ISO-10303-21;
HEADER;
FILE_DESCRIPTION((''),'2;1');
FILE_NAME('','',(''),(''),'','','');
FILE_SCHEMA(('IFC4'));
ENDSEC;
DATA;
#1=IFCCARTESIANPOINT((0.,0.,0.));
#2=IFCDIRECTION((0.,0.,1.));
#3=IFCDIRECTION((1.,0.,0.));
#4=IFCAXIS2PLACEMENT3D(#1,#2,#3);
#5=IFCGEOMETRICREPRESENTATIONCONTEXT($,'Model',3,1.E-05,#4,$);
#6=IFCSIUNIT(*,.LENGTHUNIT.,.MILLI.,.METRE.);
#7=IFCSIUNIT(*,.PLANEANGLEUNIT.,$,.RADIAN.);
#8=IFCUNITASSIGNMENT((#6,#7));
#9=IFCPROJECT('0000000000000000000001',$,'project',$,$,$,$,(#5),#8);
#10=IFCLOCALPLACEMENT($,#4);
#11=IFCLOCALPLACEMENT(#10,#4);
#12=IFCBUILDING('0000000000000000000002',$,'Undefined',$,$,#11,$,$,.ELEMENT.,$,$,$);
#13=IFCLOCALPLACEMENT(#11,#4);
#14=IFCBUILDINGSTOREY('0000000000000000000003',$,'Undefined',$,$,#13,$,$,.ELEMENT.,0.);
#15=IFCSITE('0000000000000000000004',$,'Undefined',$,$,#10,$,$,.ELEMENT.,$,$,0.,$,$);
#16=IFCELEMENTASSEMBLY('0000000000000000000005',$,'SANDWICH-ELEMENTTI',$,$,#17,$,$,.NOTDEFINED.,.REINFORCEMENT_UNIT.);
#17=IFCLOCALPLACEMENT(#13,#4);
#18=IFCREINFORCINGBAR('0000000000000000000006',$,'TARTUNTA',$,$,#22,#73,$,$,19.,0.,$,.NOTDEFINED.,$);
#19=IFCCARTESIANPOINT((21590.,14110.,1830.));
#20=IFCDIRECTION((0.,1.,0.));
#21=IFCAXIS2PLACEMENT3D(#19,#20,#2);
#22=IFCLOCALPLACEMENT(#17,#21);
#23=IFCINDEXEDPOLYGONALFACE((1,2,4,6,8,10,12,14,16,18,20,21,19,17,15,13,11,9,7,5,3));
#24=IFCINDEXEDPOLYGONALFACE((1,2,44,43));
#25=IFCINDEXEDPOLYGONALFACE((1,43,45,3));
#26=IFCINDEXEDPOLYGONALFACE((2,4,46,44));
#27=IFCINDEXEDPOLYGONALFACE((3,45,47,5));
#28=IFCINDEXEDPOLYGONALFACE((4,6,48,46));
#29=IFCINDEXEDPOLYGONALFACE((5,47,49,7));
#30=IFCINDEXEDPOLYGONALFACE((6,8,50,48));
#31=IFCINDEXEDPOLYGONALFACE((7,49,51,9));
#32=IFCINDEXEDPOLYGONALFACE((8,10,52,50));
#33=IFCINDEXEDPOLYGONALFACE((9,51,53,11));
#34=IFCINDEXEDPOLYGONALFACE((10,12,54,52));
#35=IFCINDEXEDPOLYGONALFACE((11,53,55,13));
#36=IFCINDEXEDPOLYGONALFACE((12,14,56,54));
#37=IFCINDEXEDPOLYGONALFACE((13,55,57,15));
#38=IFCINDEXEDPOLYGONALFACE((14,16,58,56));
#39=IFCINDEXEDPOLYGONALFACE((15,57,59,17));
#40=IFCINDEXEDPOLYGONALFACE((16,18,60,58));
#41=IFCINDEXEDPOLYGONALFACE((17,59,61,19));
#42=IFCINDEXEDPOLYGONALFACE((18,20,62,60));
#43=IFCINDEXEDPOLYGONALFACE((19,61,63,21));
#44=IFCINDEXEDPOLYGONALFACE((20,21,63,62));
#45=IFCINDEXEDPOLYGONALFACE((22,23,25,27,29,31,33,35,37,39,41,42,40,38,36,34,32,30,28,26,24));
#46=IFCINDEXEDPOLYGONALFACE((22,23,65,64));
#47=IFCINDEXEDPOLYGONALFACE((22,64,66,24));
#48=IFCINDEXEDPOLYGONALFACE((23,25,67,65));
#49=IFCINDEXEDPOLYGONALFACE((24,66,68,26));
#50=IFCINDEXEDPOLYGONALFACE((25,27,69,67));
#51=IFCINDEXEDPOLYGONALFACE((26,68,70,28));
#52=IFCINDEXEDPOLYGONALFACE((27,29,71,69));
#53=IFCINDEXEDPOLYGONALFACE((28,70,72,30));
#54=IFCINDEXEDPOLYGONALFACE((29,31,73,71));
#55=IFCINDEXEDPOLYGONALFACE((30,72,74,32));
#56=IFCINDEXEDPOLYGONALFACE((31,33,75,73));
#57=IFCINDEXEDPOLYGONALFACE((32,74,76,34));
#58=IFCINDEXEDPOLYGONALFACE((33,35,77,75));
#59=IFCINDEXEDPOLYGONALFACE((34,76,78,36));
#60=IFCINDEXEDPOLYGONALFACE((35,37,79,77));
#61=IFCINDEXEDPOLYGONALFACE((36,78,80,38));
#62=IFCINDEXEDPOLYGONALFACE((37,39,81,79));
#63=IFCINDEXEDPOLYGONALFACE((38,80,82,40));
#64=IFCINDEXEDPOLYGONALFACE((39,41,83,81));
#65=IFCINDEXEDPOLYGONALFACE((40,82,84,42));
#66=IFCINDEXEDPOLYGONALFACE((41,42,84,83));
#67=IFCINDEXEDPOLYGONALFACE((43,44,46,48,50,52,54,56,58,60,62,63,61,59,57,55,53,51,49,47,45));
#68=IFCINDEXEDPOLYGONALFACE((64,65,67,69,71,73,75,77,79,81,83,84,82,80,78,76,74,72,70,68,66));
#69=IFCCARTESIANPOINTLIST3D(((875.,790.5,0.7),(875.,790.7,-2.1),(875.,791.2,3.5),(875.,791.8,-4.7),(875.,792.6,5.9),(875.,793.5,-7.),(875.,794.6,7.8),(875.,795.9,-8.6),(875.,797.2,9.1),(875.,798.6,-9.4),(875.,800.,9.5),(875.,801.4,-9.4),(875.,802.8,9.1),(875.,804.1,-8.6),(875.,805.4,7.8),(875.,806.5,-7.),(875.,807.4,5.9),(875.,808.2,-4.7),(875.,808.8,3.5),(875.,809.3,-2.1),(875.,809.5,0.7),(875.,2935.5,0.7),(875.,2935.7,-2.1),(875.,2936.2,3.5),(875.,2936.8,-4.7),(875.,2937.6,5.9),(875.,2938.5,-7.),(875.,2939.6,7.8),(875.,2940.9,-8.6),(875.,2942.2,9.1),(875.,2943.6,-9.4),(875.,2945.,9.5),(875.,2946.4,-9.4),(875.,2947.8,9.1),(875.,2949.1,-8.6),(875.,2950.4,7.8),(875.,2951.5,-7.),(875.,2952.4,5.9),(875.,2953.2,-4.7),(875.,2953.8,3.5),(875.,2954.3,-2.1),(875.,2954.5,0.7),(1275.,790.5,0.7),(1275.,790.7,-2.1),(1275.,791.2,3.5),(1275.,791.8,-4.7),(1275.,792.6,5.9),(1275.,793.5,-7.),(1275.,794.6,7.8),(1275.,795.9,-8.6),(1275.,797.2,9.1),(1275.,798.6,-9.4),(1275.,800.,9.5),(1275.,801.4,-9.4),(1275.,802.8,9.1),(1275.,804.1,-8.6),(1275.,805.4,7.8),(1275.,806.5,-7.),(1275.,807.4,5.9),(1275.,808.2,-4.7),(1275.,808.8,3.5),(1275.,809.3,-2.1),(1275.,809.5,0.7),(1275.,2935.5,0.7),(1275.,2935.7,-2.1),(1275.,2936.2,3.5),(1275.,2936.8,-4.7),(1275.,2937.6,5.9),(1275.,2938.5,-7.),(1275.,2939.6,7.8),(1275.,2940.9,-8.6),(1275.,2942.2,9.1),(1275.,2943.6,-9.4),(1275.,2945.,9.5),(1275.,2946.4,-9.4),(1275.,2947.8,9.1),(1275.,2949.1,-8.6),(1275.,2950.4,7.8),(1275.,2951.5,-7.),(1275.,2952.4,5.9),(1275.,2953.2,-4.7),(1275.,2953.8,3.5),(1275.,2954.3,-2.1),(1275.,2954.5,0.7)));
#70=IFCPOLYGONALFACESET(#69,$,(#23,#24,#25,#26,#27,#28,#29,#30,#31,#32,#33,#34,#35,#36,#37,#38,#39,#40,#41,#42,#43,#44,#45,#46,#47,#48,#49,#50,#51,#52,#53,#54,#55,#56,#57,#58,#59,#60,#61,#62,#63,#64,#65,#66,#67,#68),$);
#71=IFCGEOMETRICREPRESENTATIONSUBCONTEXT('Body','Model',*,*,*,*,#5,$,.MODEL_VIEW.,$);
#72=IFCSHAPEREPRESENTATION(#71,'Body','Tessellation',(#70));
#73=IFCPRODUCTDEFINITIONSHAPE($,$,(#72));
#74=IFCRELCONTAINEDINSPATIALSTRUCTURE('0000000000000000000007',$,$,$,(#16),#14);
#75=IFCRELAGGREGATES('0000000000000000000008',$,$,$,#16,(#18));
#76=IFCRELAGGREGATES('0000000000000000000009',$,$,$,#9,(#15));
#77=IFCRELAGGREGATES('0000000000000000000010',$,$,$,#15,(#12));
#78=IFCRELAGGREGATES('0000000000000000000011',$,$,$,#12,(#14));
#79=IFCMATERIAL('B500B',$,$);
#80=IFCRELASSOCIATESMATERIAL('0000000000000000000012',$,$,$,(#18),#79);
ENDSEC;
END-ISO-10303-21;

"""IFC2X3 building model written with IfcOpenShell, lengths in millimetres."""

from ifc_helpers import new_model, entity, si_unit, frame, origin_with_axes, place, context, subcontext, project, spatial, source, transform, mapped, material, element, aggregate, save


model = new_model("IFC2X3")

# Units and contexts
model_context = context("Model", 3, precision=1e-05, world=origin_with_axes())
body_context = subcontext(model_context, "Body", "Model", "MODEL_VIEW")
ifc_project = project(units=[si_unit("LENGTHUNIT", "METRE", prefix="MILLI"), si_unit("PLANEANGLEUNIT", "RADIAN")], contexts=[model_context])

# Site, building, storey
site_placement = place(None, origin_with_axes())
site = spatial("IfcSite", under=ifc_project, at=site_placement, Name="Undefined", CompositionType="ELEMENT", RefElevation=0.0)
building_placement = place(site_placement, origin_with_axes())
building = spatial("IfcBuilding", under=site, at=building_placement, Name="Undefined", CompositionType="ELEMENT")
storey_placement = place(building_placement, origin_with_axes())
storey = spatial("IfcBuildingStorey", under=building, at=storey_placement, Name="Undefined", CompositionType="ELEMENT", Elevation=0.0)

# Element assembly
assembly_1_placement = place(storey_placement, origin_with_axes())
assembly_1 = element("IfcElementAssembly", 1, at=assembly_1_placement, inside=storey, Name="SANDWICH-ELEMENTTI", AssemblyPlace="NOTDEFINED", PredefinedType="REINFORCEMENT_UNIT")

# Reinforcing bar
ifc_material_1 = material(Name="B500B")
shared_shape_1 = source(origin_with_axes(), body_context, "Body", "AdvancedSweptSolid", [
    entity("IfcSweptDiskSolid", entity("IfcTrimmedCurve", entity("IfcLine", entity("IfcCartesianPoint", [0.0, 0.0, 0.0]), entity("IfcVector", entity("IfcDirection", [1.0, 0.0, 0.0]), 1.0)), [entity("IfcParameterValue", 0.0)], [entity("IfcParameterValue", 400.0)], True, "PARAMETER"), 9.5, None, 0.0, 400.0),
])
shared_shape_2 = source(origin_with_axes(), body_context, "Body", "AdvancedSweptSolid", [
    entity("IfcSweptDiskSolid", entity("IfcTrimmedCurve", entity("IfcLine", entity("IfcCartesianPoint", [0.0, 0.0, 0.0]), entity("IfcVector", entity("IfcDirection", [1.0, 0.0, 0.0]), 1.0)), [entity("IfcParameterValue", 0.0)], [entity("IfcParameterValue", 400.0)], True, "PARAMETER"), 9.5, None, 0.0, 400.0),
])
reinforcing_bar_1_placement = place(assembly_1_placement, frame((21590.0, 14110.0, 1830.0), z_axis=(0.0, 1.0, 0.0), x_axis=(0.0, 0.0, 1.0)))
reinforcing_bar_1 = element("IfcReinforcingBar", 2, at=reinforcing_bar_1_placement, material=ifc_material_1, Name="TARTUNTA", BarRole="NOTDEFINED", CrossSectionArea=0.0, NominalDiameter=19.0, context=body_context, shape_type="MappedRepresentation", body=[
    mapped(shared_shape_1, transform((875.0, 800.0, 0.0))),
    mapped(shared_shape_2, transform((875.0, 2945.0, 0.0))),
])
aggregate(assembly_1, [reinforcing_bar_1])

save(model, "model.ifc")
